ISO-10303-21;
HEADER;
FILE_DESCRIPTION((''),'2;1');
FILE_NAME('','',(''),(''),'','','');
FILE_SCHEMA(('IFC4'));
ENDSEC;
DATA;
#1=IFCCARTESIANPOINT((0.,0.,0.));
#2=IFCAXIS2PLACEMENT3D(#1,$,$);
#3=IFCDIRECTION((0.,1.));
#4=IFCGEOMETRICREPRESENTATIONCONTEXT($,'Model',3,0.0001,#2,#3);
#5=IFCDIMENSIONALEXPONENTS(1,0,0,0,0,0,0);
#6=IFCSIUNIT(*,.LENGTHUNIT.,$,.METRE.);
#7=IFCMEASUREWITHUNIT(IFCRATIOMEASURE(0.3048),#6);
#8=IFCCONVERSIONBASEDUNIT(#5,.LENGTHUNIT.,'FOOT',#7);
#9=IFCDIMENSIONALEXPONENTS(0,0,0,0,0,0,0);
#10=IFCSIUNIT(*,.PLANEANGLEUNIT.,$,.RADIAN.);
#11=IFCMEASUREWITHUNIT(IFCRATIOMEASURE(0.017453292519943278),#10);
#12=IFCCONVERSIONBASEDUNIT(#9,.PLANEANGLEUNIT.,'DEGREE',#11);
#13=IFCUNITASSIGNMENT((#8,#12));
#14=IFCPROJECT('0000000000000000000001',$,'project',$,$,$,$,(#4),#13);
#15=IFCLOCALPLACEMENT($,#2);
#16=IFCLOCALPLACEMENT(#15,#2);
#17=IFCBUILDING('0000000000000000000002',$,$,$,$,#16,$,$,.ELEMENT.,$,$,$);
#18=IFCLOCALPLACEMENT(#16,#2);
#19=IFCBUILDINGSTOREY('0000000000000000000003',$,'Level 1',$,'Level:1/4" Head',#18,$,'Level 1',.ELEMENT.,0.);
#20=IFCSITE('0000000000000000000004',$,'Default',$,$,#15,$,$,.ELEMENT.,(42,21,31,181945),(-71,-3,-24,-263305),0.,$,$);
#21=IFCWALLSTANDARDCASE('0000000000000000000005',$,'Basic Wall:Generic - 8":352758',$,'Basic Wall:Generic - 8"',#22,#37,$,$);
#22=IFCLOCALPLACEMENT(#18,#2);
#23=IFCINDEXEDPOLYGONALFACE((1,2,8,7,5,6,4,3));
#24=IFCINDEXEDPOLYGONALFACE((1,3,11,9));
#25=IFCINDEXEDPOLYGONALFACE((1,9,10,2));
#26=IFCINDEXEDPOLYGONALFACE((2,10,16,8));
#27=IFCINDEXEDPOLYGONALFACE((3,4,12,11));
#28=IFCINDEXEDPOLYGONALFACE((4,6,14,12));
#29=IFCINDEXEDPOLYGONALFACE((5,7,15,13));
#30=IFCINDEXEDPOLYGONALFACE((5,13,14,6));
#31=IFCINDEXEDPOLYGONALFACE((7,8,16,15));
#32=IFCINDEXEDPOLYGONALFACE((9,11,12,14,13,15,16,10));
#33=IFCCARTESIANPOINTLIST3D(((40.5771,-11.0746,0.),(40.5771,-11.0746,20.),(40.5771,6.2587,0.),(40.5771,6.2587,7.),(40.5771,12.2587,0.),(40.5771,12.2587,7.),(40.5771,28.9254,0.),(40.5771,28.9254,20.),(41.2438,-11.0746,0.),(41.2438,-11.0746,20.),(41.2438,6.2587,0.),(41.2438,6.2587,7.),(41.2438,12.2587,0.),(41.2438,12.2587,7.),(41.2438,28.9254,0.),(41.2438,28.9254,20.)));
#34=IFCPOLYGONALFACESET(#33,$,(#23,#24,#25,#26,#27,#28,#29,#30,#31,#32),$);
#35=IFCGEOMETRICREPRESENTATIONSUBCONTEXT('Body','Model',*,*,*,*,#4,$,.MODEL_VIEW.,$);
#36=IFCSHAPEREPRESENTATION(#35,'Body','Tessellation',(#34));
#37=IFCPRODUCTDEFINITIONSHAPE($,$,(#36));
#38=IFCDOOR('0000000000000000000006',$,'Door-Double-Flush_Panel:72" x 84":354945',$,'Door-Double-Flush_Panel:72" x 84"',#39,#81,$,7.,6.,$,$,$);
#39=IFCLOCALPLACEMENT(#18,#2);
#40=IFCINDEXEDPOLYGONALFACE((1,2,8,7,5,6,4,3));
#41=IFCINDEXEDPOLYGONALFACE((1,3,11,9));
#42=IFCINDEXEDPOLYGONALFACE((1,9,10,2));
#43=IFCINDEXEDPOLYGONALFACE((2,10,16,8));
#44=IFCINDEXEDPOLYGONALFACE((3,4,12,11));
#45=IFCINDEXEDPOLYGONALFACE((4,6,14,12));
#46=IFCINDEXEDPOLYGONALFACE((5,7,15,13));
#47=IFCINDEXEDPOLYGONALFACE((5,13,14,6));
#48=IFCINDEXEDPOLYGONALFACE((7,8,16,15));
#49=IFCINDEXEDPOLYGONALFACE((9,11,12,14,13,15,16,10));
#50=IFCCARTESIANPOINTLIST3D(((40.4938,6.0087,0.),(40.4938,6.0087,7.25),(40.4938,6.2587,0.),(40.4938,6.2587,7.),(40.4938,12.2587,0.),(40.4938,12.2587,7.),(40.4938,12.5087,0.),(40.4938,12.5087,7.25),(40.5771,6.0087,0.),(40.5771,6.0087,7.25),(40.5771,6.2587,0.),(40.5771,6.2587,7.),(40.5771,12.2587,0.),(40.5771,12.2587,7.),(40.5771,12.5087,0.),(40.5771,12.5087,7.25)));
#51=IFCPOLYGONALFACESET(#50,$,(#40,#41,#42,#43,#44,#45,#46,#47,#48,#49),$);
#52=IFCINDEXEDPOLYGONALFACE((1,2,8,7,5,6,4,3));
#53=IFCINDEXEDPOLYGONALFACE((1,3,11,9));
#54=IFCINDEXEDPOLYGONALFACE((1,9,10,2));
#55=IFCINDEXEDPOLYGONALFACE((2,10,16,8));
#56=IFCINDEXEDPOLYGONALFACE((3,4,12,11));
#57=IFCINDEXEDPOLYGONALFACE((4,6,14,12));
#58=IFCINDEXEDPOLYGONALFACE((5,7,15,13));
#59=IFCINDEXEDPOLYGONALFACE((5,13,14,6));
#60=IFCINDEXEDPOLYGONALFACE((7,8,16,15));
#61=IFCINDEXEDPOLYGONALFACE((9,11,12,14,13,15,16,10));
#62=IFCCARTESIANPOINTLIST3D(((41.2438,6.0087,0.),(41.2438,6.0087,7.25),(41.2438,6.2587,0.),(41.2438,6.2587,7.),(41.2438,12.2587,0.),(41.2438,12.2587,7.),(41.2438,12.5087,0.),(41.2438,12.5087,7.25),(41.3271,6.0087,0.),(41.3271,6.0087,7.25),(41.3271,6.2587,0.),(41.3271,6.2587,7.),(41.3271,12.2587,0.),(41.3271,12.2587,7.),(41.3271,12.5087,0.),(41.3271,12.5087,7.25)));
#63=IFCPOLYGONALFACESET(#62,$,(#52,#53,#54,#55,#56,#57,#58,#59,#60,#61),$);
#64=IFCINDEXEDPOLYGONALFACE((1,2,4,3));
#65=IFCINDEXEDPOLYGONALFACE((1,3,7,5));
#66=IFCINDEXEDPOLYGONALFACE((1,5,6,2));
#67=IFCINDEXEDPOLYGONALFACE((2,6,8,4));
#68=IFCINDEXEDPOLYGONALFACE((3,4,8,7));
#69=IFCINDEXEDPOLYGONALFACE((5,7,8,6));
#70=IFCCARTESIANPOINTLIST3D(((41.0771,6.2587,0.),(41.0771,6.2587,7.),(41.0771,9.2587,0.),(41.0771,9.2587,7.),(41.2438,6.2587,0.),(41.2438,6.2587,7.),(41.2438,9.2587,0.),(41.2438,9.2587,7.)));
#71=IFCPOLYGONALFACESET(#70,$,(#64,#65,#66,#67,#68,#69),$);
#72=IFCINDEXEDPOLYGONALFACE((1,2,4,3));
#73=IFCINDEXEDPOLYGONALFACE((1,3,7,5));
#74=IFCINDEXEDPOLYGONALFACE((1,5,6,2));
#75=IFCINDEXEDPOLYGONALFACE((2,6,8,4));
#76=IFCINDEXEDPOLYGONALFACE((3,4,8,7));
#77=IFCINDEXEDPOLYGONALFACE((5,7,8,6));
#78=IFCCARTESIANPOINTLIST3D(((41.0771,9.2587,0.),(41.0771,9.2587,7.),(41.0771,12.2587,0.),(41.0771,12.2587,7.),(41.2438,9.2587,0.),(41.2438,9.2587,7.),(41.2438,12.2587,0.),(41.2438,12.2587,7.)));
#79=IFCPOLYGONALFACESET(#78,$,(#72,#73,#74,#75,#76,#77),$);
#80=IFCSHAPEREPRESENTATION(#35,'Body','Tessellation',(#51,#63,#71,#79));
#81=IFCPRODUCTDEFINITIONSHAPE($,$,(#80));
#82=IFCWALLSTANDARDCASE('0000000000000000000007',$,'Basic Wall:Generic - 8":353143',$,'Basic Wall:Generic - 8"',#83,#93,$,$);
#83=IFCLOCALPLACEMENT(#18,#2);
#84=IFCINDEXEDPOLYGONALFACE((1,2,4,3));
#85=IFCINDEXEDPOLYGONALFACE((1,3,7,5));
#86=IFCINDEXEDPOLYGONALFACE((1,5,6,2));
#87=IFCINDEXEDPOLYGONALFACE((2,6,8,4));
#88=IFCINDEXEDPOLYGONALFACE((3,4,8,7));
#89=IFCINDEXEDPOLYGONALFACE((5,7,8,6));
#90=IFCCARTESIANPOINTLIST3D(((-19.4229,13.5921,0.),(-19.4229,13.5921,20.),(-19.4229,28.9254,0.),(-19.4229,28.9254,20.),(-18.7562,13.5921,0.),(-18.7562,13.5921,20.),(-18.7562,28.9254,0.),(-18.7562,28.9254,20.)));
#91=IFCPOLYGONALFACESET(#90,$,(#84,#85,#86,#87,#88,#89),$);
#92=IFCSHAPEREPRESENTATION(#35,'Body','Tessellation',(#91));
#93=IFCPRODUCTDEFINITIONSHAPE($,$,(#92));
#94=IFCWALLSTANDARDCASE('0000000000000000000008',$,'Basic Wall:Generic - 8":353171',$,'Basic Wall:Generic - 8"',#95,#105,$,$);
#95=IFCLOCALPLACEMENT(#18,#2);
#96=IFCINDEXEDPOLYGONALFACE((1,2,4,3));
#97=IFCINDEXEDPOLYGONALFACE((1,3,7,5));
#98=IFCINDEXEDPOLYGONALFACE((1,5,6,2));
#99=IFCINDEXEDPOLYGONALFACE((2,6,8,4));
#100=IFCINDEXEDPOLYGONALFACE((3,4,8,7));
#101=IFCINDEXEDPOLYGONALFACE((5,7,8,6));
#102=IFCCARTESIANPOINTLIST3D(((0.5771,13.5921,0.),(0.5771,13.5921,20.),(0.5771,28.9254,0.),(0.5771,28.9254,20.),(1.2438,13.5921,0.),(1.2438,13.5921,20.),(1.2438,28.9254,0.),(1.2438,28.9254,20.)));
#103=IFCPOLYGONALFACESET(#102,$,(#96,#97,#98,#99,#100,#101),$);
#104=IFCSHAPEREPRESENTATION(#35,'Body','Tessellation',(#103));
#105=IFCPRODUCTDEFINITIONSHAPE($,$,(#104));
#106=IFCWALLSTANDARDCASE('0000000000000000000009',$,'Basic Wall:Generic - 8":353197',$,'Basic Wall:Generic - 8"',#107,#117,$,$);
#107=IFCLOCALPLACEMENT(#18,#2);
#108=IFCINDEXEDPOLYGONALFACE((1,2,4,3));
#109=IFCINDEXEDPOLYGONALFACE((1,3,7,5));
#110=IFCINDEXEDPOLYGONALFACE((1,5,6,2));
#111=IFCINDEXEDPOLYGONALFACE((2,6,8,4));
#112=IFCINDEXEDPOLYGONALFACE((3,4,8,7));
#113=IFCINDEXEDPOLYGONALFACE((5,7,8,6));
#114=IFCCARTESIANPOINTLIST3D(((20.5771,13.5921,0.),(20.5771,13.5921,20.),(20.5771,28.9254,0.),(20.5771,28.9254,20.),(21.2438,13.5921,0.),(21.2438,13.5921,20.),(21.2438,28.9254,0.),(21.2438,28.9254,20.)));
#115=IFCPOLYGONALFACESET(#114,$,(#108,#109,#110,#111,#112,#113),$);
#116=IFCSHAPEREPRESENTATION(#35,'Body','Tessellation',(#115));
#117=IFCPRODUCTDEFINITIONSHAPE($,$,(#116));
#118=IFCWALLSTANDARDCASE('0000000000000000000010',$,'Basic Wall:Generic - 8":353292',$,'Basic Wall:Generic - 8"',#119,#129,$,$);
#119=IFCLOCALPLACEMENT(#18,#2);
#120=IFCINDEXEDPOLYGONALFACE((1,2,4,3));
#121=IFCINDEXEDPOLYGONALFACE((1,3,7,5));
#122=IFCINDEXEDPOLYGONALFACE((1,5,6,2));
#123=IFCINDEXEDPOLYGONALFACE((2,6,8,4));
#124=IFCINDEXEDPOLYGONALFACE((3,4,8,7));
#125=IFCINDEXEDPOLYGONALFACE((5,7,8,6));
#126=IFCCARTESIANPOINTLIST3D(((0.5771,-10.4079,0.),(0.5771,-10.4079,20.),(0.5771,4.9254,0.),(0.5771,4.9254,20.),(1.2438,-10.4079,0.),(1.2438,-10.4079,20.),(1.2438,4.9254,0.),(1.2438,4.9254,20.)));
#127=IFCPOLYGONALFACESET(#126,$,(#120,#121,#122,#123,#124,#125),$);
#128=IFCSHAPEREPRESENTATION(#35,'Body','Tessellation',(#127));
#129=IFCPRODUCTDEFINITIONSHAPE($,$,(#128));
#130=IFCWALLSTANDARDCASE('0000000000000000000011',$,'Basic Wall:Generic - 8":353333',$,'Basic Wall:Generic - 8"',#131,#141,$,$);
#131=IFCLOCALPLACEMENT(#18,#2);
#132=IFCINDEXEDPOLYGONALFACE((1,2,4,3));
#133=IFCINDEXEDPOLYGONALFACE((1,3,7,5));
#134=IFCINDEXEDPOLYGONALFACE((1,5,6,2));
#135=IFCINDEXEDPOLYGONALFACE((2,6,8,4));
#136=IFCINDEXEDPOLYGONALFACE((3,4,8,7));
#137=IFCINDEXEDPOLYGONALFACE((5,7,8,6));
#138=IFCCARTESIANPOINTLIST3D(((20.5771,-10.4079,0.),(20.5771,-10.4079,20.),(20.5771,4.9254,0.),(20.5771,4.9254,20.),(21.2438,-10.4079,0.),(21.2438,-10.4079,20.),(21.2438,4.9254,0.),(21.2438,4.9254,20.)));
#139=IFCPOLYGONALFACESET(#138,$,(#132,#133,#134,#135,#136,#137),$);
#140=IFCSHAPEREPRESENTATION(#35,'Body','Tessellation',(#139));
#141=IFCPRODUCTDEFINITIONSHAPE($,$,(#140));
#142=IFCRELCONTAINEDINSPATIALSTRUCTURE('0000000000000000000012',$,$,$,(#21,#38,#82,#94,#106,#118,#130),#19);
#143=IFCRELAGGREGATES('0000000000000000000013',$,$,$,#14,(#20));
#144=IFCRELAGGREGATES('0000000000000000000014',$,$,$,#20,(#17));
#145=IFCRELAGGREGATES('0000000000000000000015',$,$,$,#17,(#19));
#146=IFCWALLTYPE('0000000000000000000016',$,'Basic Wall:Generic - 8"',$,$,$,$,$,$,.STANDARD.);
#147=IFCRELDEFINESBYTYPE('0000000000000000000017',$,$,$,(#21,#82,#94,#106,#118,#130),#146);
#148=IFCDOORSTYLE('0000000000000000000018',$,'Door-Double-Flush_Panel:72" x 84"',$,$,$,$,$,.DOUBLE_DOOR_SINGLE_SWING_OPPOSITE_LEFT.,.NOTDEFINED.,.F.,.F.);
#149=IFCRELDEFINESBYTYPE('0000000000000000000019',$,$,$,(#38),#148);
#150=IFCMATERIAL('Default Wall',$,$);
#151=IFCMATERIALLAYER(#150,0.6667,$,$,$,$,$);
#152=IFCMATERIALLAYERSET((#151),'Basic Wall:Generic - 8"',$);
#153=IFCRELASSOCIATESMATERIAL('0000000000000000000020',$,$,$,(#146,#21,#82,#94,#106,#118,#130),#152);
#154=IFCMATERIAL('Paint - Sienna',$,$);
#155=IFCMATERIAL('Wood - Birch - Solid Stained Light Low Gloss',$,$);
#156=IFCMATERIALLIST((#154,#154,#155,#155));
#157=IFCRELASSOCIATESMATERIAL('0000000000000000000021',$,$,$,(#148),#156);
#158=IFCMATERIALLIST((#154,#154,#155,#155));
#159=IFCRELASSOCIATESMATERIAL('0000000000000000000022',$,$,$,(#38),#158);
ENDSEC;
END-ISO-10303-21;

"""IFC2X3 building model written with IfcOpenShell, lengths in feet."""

from ifc_helpers import new_model, entity, si_unit, converted_unit, direction, frame, frame_2d, origin, place, context, subcontext, project, spatial, polyline, rectangle, outline, extrude, source, transform, mapped, material, material_list, layer, layer_set, layer_usage, type_object, type_shapes, element, fill, save


model = new_model("IFC2X3")

# Units and contexts
model_context = context("Model", 3, precision=0.0001, world=origin(), true_north=direction((0.0, 1.0)))
body_context = subcontext(model_context, "Body", "Model", "MODEL_VIEW")
ifc_project = project(units=[converted_unit("LENGTHUNIT", "FOOT", entity("IfcRatioMeasure", 0.3048), si_unit("LENGTHUNIT", "METRE"), dimensions=[1, 0, 0, 0, 0, 0, 0]), converted_unit("PLANEANGLEUNIT", "DEGREE", entity("IfcRatioMeasure", 0.017453292519943278), si_unit("PLANEANGLEUNIT", "RADIAN"), dimensions=[0, 0, 0, 0, 0, 0, 0])], contexts=[model_context])

# Site, building, storey
site_placement = place(None, origin())
site = spatial("IfcSite", under=ifc_project, at=site_placement, Name="Default", CompositionType="ELEMENT", RefLatitude=(42, 21, 31, 181945), RefLongitude=(-71, -3, -24, -263305), RefElevation=0.0)
building_placement = place(site_placement, origin())
building = spatial("IfcBuilding", under=site, at=building_placement, CompositionType="ELEMENT")
storey_placement = place(building_placement, origin())
storey = spatial("IfcBuildingStorey", under=building, at=storey_placement, Name="Level 1", ObjectType="Level:1/4\" Head", LongName="Level 1", CompositionType="ELEMENT", Elevation=0.0)

# Wall, opening, door
ifc_material_1 = material(Name="Default Wall")
ifc_layer = layer(ifc_material_1, 0.6667)
ifc_layer_set = layer_set([ifc_layer], Name="Basic Wall:Generic - 8\"")
ifc_layer_usage_1 = layer_usage(ifc_layer_set, "AXIS2", "NEGATIVE", 0.3333)
wall_type = type_object("IfcWallType", Name="Basic Wall:Generic - 8\"", PredefinedType="STANDARD", material=ifc_layer_set)
wall_1_placement = place(storey_placement, frame((40.9105, 28.9254, 0.0), z_axis=(0.0, 0.0, 1.0), x_axis=(0.0, -1.0, 0.0)))
wall_1 = element("IfcWallStandardCase", 1, at=wall_1_placement, inside=storey, type_object=wall_type, material=ifc_layer_usage_1, Name="Basic Wall:Generic - 8\":352758", ObjectType="Basic Wall:Generic - 8\"", context=body_context, shape_type="SweptSolid", body=[
    extrude(rectangle(XDim=40.0, YDim=0.6667, at=frame_2d((20.0, 0.0), x_axis=(1.0, 0.0))), origin(), (0.0, 0.0, 1.0), 20.0),
])
opening_1_placement = place(wall_1_placement, frame((16.6667, -0.3333, 0.0)))
opening_1 = element("IfcOpeningElement", 2, at=opening_1_placement, cuts=wall_1, ObjectType="Opening", context=body_context, shape_type="SweptSolid", body=[
    extrude(rectangle(XDim=7.0, YDim=6.0, at=frame_2d((3.5, 3.0), x_axis=(1.0, 0.0))), frame((0.0, 0.0, 0.0), z_axis=(0.0, 1.0, 0.0), x_axis=(0.0, 0.0, 1.0)), (0.0, 0.0, 1.0), 0.6667),
])
ifc_material_2 = material(Name="Paint - Sienna")
ifc_material_3 = material(Name="Wood - Birch - Solid Stained Light Low Gloss")
ifc_material_list_1 = material_list([ifc_material_2, ifc_material_2, ifc_material_3, ifc_material_3])
ifc_material_list_2 = material_list([ifc_material_2, ifc_material_2, ifc_material_3, ifc_material_3])
door_style = type_object("IfcDoorStyle", Name="Door-Double-Flush_Panel:72\" x 84\"", ConstructionType="NOTDEFINED", OperationType="DOUBLE_DOOR_SINGLE_SWING_OPPOSITE_LEFT", ParameterTakesPrecedence=False, Sizeable=False, material=ifc_material_list_2)
shared_shape_1 = source(origin(), body_context, "Body", "SweptSolid", [
    extrude(outline(polyline([(-3.4375, 3.0), (3.5625, 3.0), (3.5625, 3.25), (-3.6875, 3.25), (-3.6875, -3.25), (3.5625, -3.25), (3.5625, -3.0), (-3.4375, -3.0), (-3.4375, 3.0)])), frame((3.0, -0.0833, 3.5625), z_axis=(0.0, 1.0, 0.0), x_axis=(0.0, 0.0, -1.0)), (0.0, 0.0, 1.0), 0.0833),
    extrude(outline(polyline([(-3.4375, 3.0), (3.5625, 3.0), (3.5625, 3.25), (-3.6875, 3.25), (-3.6875, -3.25), (3.5625, -3.25), (3.5625, -3.0), (-3.4375, -3.0), (-3.4375, 3.0)])), frame((3.0, 0.6667, 3.5625), z_axis=(0.0, 1.0, 0.0), x_axis=(0.0, 0.0, -1.0)), (0.0, 0.0, 1.0), 0.0833),
    extrude(rectangle(XDim=0.1667, YDim=3.0, at=frame_2d((0.0, 0.0), x_axis=(1.0, 0.0))), frame((4.5, 0.5833, 0.0), z_axis=(0.0, 0.0, 1.0), x_axis=(0.0, -1.0, 0.0)), (0.0, 0.0, 1.0), 7.0),
    extrude(rectangle(XDim=0.1667, YDim=3.0, at=frame_2d((0.0, 0.0), x_axis=(1.0, 0.0))), frame((1.5, 0.5833, 0.0), z_axis=(0.0, 0.0, 1.0), x_axis=(0.0, -1.0, 0.0)), (0.0, 0.0, 1.0), 7.0),
])
type_shapes(door_style, [shared_shape_1])
door_placement = place(opening_1_placement, origin())
door = element("IfcDoor", 3, at=door_placement, inside=storey, type_object=door_style, material=ifc_material_list_1, Name="Door-Double-Flush_Panel:72\" x 84\":354945", ObjectType="Door-Double-Flush_Panel:72\" x 84\"", OverallHeight=7.0, OverallWidth=6.0, context=body_context, shape_type="MappedRepresentation", body=[
    mapped(shared_shape_1, transform((0.0, 0.0, 0.0), scale=1.0)),
])
fill(opening_1, door)

# Walls
ifc_layer_usage_2 = layer_usage(ifc_layer_set, "AXIS2", "NEGATIVE", 0.3333)
wall_2_placement = place(storey_placement, frame((-19.0895, 28.9254, 0.0), z_axis=(0.0, 0.0, 1.0), x_axis=(0.0, -1.0, 0.0)))
element("IfcWallStandardCase", 4, at=wall_2_placement, inside=storey, type_object=wall_type, material=ifc_layer_usage_2, Name="Basic Wall:Generic - 8\":353143", ObjectType="Basic Wall:Generic - 8\"", context=body_context, shape_type="SweptSolid", body=[
    extrude(rectangle(XDim=15.3333, YDim=0.6667, at=frame_2d((7.6667, 0.0), x_axis=(-1.0, 0.0))), origin(), (0.0, 0.0, 1.0), 20.0),
])
ifc_layer_usage_3 = layer_usage(ifc_layer_set, "AXIS2", "NEGATIVE", 0.3333)
wall_3_placement = place(storey_placement, frame((0.9105, 28.9254, 0.0), z_axis=(0.0, 0.0, 1.0), x_axis=(0.0, -1.0, 0.0)))
element("IfcWallStandardCase", 5, at=wall_3_placement, inside=storey, type_object=wall_type, material=ifc_layer_usage_3, Name="Basic Wall:Generic - 8\":353171", ObjectType="Basic Wall:Generic - 8\"", context=body_context, shape_type="SweptSolid", body=[
    extrude(rectangle(XDim=15.3333, YDim=0.6667, at=frame_2d((7.6667, 0.0), x_axis=(-1.0, 0.0))), origin(), (0.0, 0.0, 1.0), 20.0),
])
ifc_layer_usage_4 = layer_usage(ifc_layer_set, "AXIS2", "NEGATIVE", 0.3333)
wall_4_placement = place(storey_placement, frame((20.9105, 28.9254, 0.0), z_axis=(0.0, 0.0, 1.0), x_axis=(0.0, -1.0, 0.0)))
element("IfcWallStandardCase", 6, at=wall_4_placement, inside=storey, type_object=wall_type, material=ifc_layer_usage_4, Name="Basic Wall:Generic - 8\":353197", ObjectType="Basic Wall:Generic - 8\"", context=body_context, shape_type="SweptSolid", body=[
    extrude(rectangle(XDim=15.3333, YDim=0.6667, at=frame_2d((7.6667, 0.0), x_axis=(-1.0, 0.0))), origin(), (0.0, 0.0, 1.0), 20.0),
])
ifc_layer_usage_5 = layer_usage(ifc_layer_set, "AXIS2", "NEGATIVE", 0.3333)
wall_5_placement = place(storey_placement, frame((0.9105, 4.9254, 0.0), z_axis=(0.0, 0.0, 1.0), x_axis=(0.0, -1.0, 0.0)))
element("IfcWallStandardCase", 7, at=wall_5_placement, inside=storey, type_object=wall_type, material=ifc_layer_usage_5, Name="Basic Wall:Generic - 8\":353292", ObjectType="Basic Wall:Generic - 8\"", context=body_context, shape_type="SweptSolid", body=[
    extrude(rectangle(XDim=15.3333, YDim=0.6667, at=frame_2d((7.6667, 0.0), x_axis=(-1.0, 0.0))), origin(), (0.0, 0.0, 1.0), 20.0),
])
ifc_layer_usage_6 = layer_usage(ifc_layer_set, "AXIS2", "NEGATIVE", 0.3333)
wall_6_placement = place(storey_placement, frame((20.9105, 4.9254, 0.0), z_axis=(0.0, 0.0, 1.0), x_axis=(0.0, -1.0, 0.0)))
element("IfcWallStandardCase", 8, at=wall_6_placement, inside=storey, type_object=wall_type, material=ifc_layer_usage_6, Name="Basic Wall:Generic - 8\":353333", ObjectType="Basic Wall:Generic - 8\"", context=body_context, shape_type="SweptSolid", body=[
    extrude(rectangle(XDim=15.3333, YDim=0.6667, at=frame_2d((7.6667, 0.0), x_axis=(-1.0, 0.0))), origin(), (0.0, 0.0, 1.0), 20.0),
])

save(model, "model.ifc")
